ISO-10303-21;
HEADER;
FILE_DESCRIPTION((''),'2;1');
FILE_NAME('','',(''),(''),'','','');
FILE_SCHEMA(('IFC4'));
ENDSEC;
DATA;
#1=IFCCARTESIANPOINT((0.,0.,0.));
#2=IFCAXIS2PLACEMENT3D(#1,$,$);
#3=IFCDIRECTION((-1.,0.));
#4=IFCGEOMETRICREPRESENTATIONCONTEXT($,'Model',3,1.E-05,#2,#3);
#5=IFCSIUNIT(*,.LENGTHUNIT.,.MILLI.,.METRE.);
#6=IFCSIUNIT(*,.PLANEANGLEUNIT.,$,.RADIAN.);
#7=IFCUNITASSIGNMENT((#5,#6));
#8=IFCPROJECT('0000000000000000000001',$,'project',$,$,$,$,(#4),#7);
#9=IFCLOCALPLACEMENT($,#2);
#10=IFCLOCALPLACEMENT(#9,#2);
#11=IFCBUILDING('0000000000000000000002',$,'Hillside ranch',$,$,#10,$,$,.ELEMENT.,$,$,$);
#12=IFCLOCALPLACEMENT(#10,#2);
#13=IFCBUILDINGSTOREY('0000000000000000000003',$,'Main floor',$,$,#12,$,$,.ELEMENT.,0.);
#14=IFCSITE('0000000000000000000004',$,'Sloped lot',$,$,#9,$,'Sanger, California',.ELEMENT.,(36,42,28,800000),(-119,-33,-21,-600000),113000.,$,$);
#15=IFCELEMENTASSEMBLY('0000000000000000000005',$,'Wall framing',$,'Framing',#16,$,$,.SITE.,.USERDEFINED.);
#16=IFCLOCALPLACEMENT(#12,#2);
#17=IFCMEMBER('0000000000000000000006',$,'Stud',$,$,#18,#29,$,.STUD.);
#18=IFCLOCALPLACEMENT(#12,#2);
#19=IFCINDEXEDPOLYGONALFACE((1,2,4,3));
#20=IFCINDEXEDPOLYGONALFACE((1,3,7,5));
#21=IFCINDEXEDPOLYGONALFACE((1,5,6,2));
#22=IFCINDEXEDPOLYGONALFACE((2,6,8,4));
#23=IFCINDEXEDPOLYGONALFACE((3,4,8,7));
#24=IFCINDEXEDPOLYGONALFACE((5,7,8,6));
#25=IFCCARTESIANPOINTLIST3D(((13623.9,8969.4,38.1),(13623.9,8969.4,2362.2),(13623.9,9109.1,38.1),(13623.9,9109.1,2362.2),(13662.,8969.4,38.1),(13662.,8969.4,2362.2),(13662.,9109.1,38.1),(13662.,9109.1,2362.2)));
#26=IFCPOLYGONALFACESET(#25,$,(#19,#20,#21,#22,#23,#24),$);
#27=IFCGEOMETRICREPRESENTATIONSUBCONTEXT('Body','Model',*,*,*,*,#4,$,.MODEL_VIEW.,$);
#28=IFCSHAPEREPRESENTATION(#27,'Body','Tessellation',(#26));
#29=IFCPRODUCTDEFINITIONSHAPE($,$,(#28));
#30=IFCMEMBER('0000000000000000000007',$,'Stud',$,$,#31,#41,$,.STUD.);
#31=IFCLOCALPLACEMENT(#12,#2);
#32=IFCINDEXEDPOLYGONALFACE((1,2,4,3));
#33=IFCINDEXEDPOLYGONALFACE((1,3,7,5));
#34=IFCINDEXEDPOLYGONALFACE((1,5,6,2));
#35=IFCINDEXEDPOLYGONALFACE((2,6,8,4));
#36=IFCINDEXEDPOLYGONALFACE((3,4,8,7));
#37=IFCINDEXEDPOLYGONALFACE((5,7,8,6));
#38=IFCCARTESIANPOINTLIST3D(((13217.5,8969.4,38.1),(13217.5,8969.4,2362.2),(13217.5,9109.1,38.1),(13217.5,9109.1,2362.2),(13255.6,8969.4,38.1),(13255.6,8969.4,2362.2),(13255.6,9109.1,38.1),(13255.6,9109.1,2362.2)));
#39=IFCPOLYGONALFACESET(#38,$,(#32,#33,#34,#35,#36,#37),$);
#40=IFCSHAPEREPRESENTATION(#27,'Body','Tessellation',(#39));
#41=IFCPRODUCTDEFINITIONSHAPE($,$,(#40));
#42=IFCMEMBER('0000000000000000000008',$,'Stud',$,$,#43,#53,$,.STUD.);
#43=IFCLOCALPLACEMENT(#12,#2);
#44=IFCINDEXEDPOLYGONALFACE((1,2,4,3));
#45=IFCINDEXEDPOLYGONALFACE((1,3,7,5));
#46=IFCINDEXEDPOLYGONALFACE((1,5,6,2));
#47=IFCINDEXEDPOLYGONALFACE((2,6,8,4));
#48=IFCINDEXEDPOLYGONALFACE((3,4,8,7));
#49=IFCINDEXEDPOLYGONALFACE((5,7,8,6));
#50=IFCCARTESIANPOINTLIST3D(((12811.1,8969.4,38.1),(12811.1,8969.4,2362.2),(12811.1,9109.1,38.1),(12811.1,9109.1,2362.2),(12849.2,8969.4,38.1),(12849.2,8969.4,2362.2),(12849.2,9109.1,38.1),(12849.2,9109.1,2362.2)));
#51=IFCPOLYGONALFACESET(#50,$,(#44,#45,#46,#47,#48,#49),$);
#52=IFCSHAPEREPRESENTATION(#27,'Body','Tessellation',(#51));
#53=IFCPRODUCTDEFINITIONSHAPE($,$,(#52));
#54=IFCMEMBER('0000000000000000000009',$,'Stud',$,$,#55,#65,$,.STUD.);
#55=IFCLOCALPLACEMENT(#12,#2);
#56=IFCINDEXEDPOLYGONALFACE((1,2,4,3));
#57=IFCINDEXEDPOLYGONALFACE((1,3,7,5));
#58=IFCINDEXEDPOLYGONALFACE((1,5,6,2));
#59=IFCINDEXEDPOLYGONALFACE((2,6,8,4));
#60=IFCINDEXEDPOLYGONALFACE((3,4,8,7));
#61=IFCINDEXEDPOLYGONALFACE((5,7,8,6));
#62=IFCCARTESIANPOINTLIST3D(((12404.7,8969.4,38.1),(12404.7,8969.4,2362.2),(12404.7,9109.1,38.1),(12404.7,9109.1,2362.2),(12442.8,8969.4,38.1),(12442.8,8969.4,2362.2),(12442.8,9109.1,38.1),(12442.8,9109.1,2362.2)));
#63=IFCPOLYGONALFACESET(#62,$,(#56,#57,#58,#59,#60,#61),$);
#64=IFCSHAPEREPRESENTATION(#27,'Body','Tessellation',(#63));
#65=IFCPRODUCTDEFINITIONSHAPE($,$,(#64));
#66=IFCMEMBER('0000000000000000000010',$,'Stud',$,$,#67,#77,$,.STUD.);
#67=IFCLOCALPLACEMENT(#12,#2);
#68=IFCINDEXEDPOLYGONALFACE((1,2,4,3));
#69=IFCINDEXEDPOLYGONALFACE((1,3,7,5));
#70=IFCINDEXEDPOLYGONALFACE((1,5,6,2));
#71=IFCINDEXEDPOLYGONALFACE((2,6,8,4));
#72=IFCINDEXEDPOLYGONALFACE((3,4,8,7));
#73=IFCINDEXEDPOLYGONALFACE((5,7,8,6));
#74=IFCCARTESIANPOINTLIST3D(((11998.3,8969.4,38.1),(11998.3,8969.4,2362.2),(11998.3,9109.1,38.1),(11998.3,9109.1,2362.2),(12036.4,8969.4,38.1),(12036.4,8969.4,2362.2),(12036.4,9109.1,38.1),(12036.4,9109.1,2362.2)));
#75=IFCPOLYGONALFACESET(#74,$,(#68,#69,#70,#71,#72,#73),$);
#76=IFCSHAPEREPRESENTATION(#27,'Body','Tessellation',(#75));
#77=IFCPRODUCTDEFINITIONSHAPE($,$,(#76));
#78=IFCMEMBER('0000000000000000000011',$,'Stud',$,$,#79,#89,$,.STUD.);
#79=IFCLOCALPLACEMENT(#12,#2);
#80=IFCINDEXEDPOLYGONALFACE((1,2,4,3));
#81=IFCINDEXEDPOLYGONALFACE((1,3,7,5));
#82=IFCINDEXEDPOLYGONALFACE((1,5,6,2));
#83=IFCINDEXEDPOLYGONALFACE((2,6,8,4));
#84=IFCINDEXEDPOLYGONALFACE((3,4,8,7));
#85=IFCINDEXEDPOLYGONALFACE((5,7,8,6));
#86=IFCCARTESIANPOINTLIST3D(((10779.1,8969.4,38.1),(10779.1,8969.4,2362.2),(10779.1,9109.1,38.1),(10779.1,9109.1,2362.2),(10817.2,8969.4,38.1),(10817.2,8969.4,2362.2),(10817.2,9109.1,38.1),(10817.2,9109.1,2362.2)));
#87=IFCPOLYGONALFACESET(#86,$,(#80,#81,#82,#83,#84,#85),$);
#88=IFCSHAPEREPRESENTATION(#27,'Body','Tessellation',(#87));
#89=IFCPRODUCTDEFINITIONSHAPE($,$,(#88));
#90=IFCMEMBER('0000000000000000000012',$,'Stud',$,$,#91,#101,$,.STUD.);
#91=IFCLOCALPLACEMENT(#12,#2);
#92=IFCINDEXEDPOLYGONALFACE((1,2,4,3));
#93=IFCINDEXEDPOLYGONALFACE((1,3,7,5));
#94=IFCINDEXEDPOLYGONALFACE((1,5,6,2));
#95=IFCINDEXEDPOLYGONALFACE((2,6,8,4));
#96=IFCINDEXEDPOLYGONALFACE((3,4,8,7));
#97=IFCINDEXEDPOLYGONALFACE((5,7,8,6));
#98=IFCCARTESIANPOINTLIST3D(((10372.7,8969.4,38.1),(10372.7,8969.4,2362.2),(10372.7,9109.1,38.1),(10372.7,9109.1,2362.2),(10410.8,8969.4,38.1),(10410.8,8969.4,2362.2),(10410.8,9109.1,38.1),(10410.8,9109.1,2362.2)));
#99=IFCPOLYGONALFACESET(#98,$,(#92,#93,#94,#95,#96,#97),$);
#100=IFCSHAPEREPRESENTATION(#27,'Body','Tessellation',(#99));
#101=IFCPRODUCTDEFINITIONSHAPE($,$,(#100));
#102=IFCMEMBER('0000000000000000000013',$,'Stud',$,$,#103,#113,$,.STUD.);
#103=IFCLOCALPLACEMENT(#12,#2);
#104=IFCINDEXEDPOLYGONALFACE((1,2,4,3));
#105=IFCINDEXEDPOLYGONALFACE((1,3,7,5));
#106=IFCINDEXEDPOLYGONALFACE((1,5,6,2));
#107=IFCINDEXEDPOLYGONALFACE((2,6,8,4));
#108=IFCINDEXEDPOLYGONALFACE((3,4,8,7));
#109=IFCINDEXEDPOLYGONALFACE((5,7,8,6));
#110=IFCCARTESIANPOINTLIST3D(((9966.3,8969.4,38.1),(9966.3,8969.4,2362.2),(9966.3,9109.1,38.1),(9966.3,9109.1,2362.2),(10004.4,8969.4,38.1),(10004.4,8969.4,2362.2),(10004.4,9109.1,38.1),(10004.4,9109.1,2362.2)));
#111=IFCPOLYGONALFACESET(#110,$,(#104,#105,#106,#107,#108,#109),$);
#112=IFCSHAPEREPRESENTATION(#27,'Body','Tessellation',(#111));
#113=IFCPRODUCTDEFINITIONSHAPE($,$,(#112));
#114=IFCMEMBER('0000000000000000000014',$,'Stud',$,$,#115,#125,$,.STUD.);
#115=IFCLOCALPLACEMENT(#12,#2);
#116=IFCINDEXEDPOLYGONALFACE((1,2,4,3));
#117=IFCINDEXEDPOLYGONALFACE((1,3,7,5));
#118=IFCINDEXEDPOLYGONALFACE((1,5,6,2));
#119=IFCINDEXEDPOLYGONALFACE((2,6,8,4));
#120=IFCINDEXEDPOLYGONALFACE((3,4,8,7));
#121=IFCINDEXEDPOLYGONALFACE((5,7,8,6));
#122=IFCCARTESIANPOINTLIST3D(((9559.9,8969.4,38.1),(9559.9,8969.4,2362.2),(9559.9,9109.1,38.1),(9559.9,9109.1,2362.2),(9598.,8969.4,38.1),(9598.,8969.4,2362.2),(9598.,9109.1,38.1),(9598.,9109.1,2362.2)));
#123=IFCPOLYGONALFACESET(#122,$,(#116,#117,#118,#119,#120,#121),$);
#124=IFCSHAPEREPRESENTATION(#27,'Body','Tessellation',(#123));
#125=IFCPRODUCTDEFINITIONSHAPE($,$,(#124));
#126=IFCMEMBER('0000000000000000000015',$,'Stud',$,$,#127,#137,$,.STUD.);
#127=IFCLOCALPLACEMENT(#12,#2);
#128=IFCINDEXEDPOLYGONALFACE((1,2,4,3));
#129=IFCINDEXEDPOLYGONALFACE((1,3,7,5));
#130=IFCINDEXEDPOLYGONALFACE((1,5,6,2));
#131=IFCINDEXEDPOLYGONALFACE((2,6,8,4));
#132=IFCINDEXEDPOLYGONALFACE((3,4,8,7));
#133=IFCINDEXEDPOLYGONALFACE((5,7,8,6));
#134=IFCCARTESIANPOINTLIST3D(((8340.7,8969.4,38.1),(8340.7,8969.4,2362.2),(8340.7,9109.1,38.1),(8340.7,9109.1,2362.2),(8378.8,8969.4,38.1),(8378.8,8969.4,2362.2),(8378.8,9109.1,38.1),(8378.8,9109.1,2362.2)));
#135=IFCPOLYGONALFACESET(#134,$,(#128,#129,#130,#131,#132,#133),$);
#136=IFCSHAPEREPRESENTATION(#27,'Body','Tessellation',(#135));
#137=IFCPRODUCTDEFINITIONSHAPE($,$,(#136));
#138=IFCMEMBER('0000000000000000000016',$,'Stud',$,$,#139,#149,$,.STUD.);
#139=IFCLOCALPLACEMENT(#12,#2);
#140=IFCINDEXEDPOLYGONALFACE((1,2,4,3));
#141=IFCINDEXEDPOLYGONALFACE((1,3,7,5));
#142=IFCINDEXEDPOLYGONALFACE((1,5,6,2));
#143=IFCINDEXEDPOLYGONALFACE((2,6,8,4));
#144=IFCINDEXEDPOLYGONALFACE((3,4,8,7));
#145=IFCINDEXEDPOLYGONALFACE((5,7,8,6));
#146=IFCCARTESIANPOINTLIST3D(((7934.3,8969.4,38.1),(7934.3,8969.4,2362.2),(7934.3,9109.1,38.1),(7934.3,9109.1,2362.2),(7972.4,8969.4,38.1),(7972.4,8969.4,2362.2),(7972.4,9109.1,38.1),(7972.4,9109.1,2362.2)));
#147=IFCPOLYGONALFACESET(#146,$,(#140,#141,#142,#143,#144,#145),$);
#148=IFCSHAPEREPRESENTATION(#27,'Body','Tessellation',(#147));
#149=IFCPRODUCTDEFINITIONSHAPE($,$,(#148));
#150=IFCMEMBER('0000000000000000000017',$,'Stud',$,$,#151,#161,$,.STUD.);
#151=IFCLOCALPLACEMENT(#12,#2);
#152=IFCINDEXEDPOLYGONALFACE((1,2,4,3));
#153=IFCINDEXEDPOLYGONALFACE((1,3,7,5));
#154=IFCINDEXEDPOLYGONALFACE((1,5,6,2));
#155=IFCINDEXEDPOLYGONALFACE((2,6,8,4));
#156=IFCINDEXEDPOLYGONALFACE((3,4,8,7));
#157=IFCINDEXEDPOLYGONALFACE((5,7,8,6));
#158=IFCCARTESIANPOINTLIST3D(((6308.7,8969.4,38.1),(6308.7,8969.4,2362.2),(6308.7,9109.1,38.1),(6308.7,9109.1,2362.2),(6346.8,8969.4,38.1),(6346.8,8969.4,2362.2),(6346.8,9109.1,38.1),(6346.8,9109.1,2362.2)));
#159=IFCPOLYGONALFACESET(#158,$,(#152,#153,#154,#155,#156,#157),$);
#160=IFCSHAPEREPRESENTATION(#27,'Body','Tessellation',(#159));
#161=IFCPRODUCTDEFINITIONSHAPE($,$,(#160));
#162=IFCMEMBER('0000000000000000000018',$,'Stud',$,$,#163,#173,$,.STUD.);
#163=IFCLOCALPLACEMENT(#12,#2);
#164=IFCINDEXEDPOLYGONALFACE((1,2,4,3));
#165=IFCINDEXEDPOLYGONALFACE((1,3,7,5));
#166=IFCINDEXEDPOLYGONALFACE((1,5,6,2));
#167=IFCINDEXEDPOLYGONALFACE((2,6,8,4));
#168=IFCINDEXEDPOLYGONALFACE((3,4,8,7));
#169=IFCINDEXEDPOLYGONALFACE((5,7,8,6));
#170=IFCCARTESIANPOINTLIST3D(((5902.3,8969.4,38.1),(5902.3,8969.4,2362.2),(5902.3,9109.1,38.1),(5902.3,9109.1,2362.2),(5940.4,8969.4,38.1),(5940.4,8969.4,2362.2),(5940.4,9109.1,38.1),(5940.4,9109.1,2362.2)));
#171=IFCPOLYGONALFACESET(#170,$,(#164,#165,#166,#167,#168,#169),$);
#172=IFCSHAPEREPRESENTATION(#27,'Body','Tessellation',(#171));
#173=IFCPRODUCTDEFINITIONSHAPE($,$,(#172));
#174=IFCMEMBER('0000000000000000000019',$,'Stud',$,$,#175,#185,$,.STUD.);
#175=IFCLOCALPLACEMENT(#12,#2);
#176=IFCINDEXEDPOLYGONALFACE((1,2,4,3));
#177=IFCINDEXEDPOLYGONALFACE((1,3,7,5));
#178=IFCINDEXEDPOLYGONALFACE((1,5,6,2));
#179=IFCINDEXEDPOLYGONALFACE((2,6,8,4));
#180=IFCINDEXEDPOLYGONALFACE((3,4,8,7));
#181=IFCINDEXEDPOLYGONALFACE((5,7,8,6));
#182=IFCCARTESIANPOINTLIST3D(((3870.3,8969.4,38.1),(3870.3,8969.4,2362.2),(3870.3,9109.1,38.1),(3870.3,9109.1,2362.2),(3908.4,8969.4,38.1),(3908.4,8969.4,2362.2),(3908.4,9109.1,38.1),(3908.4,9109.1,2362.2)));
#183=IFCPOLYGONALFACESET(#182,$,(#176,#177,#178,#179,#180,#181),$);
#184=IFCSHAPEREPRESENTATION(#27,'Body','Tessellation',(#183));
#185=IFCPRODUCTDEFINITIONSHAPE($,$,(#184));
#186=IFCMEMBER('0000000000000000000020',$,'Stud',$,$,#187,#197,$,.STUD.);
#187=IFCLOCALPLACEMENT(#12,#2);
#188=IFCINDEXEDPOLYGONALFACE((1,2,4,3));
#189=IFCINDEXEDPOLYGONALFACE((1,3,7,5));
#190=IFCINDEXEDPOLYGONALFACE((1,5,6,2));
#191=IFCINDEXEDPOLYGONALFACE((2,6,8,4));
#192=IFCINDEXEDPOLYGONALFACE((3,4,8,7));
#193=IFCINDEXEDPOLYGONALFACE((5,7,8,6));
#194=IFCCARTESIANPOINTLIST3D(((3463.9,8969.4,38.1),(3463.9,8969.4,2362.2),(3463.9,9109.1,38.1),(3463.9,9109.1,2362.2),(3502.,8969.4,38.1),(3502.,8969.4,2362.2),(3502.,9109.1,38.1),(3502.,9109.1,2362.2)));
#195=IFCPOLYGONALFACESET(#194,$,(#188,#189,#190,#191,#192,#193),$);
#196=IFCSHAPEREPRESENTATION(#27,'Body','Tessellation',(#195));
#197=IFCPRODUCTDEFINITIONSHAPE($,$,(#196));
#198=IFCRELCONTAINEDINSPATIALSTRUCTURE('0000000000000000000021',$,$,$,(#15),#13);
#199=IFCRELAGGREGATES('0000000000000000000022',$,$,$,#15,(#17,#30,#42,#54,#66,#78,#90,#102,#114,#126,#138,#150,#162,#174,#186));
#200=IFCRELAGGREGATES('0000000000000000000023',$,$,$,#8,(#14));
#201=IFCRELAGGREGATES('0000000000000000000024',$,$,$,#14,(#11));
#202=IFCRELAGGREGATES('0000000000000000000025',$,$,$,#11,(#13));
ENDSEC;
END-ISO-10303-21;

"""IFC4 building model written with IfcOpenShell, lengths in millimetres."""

from ifc_helpers import new_model, si_unit, direction, frame, origin, origin_with_axes, place, context, subcontext, project, spatial, polyline, outline, extrude, element, aggregate, save


model = new_model("IFC4")

# Units and contexts
model_context = context("Model", 3, precision=1e-05, world=origin(), true_north=direction((-1.0, 0.0)))
body_context = subcontext(model_context, "Body", "Model", "MODEL_VIEW")
ifc_project = project(units=[si_unit("LENGTHUNIT", "METRE", prefix="MILLI"), si_unit("PLANEANGLEUNIT", "RADIAN")], contexts=[model_context])

# Site, building, storey
site_placement = place(None, origin())
site = spatial("IfcSite", under=ifc_project, at=site_placement, Name="Sloped lot", LongName="Sanger, California", CompositionType="ELEMENT", RefLatitude=(36, 42, 28, 800000), RefLongitude=(-119, -33, -21, -600000), RefElevation=113000.0)
building_placement = place(site_placement, origin())
building = spatial("IfcBuilding", under=site, at=building_placement, Name="Hillside ranch", CompositionType="ELEMENT")
storey_placement = place(building_placement, origin())
storey = spatial("IfcBuildingStorey", under=building, at=storey_placement, Name="Main floor", CompositionType="ELEMENT", Elevation=0.0)

# Element assembly, members
assembly_placement = place(storey_placement, origin_with_axes())
assembly = element("IfcElementAssembly", 1, at=assembly_placement, inside=storey, Name="Wall framing", ObjectType="Framing", AssemblyPlace="SITE", PredefinedType="USERDEFINED")
member_1_placement = place(storey_placement, origin_with_axes())
member_1 = element("IfcMember", 2, at=member_1_placement, Name="Stud", PredefinedType="STUD", context=body_context, shape_type="SweptSolid", body=[
    extrude(outline(polyline([(0.0, 0.0), (38.1, 0.0), (38.1, 139.7), (0.0, 139.7), (0.0, 0.0)])), frame((13662.0, 9109.1, 38.1), z_axis=(0.0, 0.0, 1.0), x_axis=(-1.0, 0.0, 0.0)), (0.0, 0.0, 1.0), 2324.1),
])
member_2_placement = place(storey_placement, origin_with_axes())
member_2 = element("IfcMember", 3, at=member_2_placement, Name="Stud", PredefinedType="STUD", context=body_context, shape_type="SweptSolid", body=[
    extrude(outline(polyline([(0.0, 0.0), (38.1, 0.0), (38.1, 139.7), (0.0, 139.7), (0.0, 0.0)])), frame((13255.6, 9109.1, 38.1), z_axis=(0.0, 0.0, 1.0), x_axis=(-1.0, 0.0, 0.0)), (0.0, 0.0, 1.0), 2324.1),
])
member_3_placement = place(storey_placement, origin_with_axes())
member_3 = element("IfcMember", 4, at=member_3_placement, Name="Stud", PredefinedType="STUD", context=body_context, shape_type="SweptSolid", body=[
    extrude(outline(polyline([(0.0, 0.0), (38.1, 0.0), (38.1, 139.7), (0.0, 139.7), (0.0, 0.0)])), frame((12849.2, 9109.1, 38.1), z_axis=(0.0, 0.0, 1.0), x_axis=(-1.0, 0.0, 0.0)), (0.0, 0.0, 1.0), 2324.1),
])
member_4_placement = place(storey_placement, origin_with_axes())
member_4 = element("IfcMember", 5, at=member_4_placement, Name="Stud", PredefinedType="STUD", context=body_context, shape_type="SweptSolid", body=[
    extrude(outline(polyline([(0.0, 0.0), (38.1, 0.0), (38.1, 139.7), (0.0, 139.7), (0.0, 0.0)])), frame((12442.8, 9109.1, 38.1), z_axis=(0.0, 0.0, 1.0), x_axis=(-1.0, 0.0, 0.0)), (0.0, 0.0, 1.0), 2324.1),
])
member_5_placement = place(storey_placement, origin_with_axes())
member_5 = element("IfcMember", 6, at=member_5_placement, Name="Stud", PredefinedType="STUD", context=body_context, shape_type="SweptSolid", body=[
    extrude(outline(polyline([(0.0, 0.0), (38.1, 0.0), (38.1, 139.7), (0.0, 139.7), (0.0, 0.0)])), frame((12036.4, 9109.1, 38.1), z_axis=(0.0, 0.0, 1.0), x_axis=(-1.0, 0.0, 0.0)), (0.0, 0.0, 1.0), 2324.1),
])
member_6_placement = place(storey_placement, origin_with_axes())
member_6 = element("IfcMember", 7, at=member_6_placement, Name="Stud", PredefinedType="STUD", context=body_context, shape_type="SweptSolid", body=[
    extrude(outline(polyline([(0.0, 0.0), (38.1, 0.0), (38.1, 139.7), (0.0, 139.7), (0.0, 0.0)])), frame((10817.2, 9109.1, 38.1), z_axis=(0.0, 0.0, 1.0), x_axis=(-1.0, 0.0, 0.0)), (0.0, 0.0, 1.0), 2324.1),
])
member_7_placement = place(storey_placement, origin_with_axes())
member_7 = element("IfcMember", 8, at=member_7_placement, Name="Stud", PredefinedType="STUD", context=body_context, shape_type="SweptSolid", body=[
    extrude(outline(polyline([(0.0, 0.0), (38.1, 0.0), (38.1, 139.7), (0.0, 139.7), (0.0, 0.0)])), frame((10410.8, 9109.1, 38.1), z_axis=(0.0, 0.0, 1.0), x_axis=(-1.0, 0.0, 0.0)), (0.0, 0.0, 1.0), 2324.1),
])
member_8_placement = place(storey_placement, origin_with_axes())
member_8 = element("IfcMember", 9, at=member_8_placement, Name="Stud", PredefinedType="STUD", context=body_context, shape_type="SweptSolid", body=[
    extrude(outline(polyline([(0.0, 0.0), (38.1, 0.0), (38.1, 139.7), (0.0, 139.7), (0.0, 0.0)])), frame((10004.4, 9109.1, 38.1), z_axis=(0.0, 0.0, 1.0), x_axis=(-1.0, 0.0, 0.0)), (0.0, 0.0, 1.0), 2324.1),
])
member_9_placement = place(storey_placement, origin_with_axes())
member_9 = element("IfcMember", 10, at=member_9_placement, Name="Stud", PredefinedType="STUD", context=body_context, shape_type="SweptSolid", body=[
    extrude(outline(polyline([(0.0, 0.0), (38.1, 0.0), (38.1, 139.7), (0.0, 139.7), (0.0, 0.0)])), frame((9598.0, 9109.1, 38.1), z_axis=(0.0, 0.0, 1.0), x_axis=(-1.0, 0.0, 0.0)), (0.0, 0.0, 1.0), 2324.1),
])
member_10_placement = place(storey_placement, origin_with_axes())
member_10 = element("IfcMember", 11, at=member_10_placement, Name="Stud", PredefinedType="STUD", context=body_context, shape_type="SweptSolid", body=[
    extrude(outline(polyline([(0.0, 0.0), (38.1, 0.0), (38.1, 139.7), (0.0, 139.7), (0.0, 0.0)])), frame((8378.8, 9109.1, 38.1), z_axis=(0.0, 0.0, 1.0), x_axis=(-1.0, 0.0, 0.0)), (0.0, 0.0, 1.0), 2324.1),
])
member_11_placement = place(storey_placement, origin_with_axes())
member_11 = element("IfcMember", 12, at=member_11_placement, Name="Stud", PredefinedType="STUD", context=body_context, shape_type="SweptSolid", body=[
    extrude(outline(polyline([(0.0, 0.0), (38.1, 0.0), (38.1, 139.7), (0.0, 139.7), (0.0, 0.0)])), frame((7972.4, 9109.1, 38.1), z_axis=(0.0, 0.0, 1.0), x_axis=(-1.0, 0.0, 0.0)), (0.0, 0.0, 1.0), 2324.1),
])
member_12_placement = place(storey_placement, origin_with_axes())
member_12 = element("IfcMember", 13, at=member_12_placement, Name="Stud", PredefinedType="STUD", context=body_context, shape_type="SweptSolid", body=[
    extrude(outline(polyline([(0.0, 0.0), (38.1, 0.0), (38.1, 139.7), (0.0, 139.7), (0.0, 0.0)])), frame((6346.8, 9109.1, 38.1), z_axis=(0.0, 0.0, 1.0), x_axis=(-1.0, 0.0, 0.0)), (0.0, 0.0, 1.0), 2324.1),
])
member_13_placement = place(storey_placement, origin_with_axes())
member_13 = element("IfcMember", 14, at=member_13_placement, Name="Stud", PredefinedType="STUD", context=body_context, shape_type="SweptSolid", body=[
    extrude(outline(polyline([(0.0, 0.0), (38.1, 0.0), (38.1, 139.7), (0.0, 139.7), (0.0, 0.0)])), frame((5940.4, 9109.1, 38.1), z_axis=(0.0, 0.0, 1.0), x_axis=(-1.0, 0.0, 0.0)), (0.0, 0.0, 1.0), 2324.1),
])
member_14_placement = place(storey_placement, origin_with_axes())
member_14 = element("IfcMember", 15, at=member_14_placement, Name="Stud", PredefinedType="STUD", context=body_context, shape_type="SweptSolid", body=[
    extrude(outline(polyline([(0.0, 0.0), (38.1, 0.0), (38.1, 139.7), (0.0, 139.7), (0.0, 0.0)])), frame((3908.4, 9109.1, 38.1), z_axis=(0.0, 0.0, 1.0), x_axis=(-1.0, 0.0, 0.0)), (0.0, 0.0, 1.0), 2324.1),
])
member_15_placement = place(storey_placement, origin_with_axes())
member_15 = element("IfcMember", 16, at=member_15_placement, Name="Stud", PredefinedType="STUD", context=body_context, shape_type="SweptSolid", body=[
    extrude(outline(polyline([(0.0, 0.0), (38.1, 0.0), (38.1, 139.7), (0.0, 139.7), (0.0, 0.0)])), frame((3502.0, 9109.1, 38.1), z_axis=(0.0, 0.0, 1.0), x_axis=(-1.0, 0.0, 0.0)), (0.0, 0.0, 1.0), 2324.1),
])
aggregate(assembly, [member_1, member_2, member_3, member_4, member_5, member_6, member_7, member_8, member_9, member_10, member_11, member_12, member_13, member_14, member_15])

save(model, "model.ifc")
